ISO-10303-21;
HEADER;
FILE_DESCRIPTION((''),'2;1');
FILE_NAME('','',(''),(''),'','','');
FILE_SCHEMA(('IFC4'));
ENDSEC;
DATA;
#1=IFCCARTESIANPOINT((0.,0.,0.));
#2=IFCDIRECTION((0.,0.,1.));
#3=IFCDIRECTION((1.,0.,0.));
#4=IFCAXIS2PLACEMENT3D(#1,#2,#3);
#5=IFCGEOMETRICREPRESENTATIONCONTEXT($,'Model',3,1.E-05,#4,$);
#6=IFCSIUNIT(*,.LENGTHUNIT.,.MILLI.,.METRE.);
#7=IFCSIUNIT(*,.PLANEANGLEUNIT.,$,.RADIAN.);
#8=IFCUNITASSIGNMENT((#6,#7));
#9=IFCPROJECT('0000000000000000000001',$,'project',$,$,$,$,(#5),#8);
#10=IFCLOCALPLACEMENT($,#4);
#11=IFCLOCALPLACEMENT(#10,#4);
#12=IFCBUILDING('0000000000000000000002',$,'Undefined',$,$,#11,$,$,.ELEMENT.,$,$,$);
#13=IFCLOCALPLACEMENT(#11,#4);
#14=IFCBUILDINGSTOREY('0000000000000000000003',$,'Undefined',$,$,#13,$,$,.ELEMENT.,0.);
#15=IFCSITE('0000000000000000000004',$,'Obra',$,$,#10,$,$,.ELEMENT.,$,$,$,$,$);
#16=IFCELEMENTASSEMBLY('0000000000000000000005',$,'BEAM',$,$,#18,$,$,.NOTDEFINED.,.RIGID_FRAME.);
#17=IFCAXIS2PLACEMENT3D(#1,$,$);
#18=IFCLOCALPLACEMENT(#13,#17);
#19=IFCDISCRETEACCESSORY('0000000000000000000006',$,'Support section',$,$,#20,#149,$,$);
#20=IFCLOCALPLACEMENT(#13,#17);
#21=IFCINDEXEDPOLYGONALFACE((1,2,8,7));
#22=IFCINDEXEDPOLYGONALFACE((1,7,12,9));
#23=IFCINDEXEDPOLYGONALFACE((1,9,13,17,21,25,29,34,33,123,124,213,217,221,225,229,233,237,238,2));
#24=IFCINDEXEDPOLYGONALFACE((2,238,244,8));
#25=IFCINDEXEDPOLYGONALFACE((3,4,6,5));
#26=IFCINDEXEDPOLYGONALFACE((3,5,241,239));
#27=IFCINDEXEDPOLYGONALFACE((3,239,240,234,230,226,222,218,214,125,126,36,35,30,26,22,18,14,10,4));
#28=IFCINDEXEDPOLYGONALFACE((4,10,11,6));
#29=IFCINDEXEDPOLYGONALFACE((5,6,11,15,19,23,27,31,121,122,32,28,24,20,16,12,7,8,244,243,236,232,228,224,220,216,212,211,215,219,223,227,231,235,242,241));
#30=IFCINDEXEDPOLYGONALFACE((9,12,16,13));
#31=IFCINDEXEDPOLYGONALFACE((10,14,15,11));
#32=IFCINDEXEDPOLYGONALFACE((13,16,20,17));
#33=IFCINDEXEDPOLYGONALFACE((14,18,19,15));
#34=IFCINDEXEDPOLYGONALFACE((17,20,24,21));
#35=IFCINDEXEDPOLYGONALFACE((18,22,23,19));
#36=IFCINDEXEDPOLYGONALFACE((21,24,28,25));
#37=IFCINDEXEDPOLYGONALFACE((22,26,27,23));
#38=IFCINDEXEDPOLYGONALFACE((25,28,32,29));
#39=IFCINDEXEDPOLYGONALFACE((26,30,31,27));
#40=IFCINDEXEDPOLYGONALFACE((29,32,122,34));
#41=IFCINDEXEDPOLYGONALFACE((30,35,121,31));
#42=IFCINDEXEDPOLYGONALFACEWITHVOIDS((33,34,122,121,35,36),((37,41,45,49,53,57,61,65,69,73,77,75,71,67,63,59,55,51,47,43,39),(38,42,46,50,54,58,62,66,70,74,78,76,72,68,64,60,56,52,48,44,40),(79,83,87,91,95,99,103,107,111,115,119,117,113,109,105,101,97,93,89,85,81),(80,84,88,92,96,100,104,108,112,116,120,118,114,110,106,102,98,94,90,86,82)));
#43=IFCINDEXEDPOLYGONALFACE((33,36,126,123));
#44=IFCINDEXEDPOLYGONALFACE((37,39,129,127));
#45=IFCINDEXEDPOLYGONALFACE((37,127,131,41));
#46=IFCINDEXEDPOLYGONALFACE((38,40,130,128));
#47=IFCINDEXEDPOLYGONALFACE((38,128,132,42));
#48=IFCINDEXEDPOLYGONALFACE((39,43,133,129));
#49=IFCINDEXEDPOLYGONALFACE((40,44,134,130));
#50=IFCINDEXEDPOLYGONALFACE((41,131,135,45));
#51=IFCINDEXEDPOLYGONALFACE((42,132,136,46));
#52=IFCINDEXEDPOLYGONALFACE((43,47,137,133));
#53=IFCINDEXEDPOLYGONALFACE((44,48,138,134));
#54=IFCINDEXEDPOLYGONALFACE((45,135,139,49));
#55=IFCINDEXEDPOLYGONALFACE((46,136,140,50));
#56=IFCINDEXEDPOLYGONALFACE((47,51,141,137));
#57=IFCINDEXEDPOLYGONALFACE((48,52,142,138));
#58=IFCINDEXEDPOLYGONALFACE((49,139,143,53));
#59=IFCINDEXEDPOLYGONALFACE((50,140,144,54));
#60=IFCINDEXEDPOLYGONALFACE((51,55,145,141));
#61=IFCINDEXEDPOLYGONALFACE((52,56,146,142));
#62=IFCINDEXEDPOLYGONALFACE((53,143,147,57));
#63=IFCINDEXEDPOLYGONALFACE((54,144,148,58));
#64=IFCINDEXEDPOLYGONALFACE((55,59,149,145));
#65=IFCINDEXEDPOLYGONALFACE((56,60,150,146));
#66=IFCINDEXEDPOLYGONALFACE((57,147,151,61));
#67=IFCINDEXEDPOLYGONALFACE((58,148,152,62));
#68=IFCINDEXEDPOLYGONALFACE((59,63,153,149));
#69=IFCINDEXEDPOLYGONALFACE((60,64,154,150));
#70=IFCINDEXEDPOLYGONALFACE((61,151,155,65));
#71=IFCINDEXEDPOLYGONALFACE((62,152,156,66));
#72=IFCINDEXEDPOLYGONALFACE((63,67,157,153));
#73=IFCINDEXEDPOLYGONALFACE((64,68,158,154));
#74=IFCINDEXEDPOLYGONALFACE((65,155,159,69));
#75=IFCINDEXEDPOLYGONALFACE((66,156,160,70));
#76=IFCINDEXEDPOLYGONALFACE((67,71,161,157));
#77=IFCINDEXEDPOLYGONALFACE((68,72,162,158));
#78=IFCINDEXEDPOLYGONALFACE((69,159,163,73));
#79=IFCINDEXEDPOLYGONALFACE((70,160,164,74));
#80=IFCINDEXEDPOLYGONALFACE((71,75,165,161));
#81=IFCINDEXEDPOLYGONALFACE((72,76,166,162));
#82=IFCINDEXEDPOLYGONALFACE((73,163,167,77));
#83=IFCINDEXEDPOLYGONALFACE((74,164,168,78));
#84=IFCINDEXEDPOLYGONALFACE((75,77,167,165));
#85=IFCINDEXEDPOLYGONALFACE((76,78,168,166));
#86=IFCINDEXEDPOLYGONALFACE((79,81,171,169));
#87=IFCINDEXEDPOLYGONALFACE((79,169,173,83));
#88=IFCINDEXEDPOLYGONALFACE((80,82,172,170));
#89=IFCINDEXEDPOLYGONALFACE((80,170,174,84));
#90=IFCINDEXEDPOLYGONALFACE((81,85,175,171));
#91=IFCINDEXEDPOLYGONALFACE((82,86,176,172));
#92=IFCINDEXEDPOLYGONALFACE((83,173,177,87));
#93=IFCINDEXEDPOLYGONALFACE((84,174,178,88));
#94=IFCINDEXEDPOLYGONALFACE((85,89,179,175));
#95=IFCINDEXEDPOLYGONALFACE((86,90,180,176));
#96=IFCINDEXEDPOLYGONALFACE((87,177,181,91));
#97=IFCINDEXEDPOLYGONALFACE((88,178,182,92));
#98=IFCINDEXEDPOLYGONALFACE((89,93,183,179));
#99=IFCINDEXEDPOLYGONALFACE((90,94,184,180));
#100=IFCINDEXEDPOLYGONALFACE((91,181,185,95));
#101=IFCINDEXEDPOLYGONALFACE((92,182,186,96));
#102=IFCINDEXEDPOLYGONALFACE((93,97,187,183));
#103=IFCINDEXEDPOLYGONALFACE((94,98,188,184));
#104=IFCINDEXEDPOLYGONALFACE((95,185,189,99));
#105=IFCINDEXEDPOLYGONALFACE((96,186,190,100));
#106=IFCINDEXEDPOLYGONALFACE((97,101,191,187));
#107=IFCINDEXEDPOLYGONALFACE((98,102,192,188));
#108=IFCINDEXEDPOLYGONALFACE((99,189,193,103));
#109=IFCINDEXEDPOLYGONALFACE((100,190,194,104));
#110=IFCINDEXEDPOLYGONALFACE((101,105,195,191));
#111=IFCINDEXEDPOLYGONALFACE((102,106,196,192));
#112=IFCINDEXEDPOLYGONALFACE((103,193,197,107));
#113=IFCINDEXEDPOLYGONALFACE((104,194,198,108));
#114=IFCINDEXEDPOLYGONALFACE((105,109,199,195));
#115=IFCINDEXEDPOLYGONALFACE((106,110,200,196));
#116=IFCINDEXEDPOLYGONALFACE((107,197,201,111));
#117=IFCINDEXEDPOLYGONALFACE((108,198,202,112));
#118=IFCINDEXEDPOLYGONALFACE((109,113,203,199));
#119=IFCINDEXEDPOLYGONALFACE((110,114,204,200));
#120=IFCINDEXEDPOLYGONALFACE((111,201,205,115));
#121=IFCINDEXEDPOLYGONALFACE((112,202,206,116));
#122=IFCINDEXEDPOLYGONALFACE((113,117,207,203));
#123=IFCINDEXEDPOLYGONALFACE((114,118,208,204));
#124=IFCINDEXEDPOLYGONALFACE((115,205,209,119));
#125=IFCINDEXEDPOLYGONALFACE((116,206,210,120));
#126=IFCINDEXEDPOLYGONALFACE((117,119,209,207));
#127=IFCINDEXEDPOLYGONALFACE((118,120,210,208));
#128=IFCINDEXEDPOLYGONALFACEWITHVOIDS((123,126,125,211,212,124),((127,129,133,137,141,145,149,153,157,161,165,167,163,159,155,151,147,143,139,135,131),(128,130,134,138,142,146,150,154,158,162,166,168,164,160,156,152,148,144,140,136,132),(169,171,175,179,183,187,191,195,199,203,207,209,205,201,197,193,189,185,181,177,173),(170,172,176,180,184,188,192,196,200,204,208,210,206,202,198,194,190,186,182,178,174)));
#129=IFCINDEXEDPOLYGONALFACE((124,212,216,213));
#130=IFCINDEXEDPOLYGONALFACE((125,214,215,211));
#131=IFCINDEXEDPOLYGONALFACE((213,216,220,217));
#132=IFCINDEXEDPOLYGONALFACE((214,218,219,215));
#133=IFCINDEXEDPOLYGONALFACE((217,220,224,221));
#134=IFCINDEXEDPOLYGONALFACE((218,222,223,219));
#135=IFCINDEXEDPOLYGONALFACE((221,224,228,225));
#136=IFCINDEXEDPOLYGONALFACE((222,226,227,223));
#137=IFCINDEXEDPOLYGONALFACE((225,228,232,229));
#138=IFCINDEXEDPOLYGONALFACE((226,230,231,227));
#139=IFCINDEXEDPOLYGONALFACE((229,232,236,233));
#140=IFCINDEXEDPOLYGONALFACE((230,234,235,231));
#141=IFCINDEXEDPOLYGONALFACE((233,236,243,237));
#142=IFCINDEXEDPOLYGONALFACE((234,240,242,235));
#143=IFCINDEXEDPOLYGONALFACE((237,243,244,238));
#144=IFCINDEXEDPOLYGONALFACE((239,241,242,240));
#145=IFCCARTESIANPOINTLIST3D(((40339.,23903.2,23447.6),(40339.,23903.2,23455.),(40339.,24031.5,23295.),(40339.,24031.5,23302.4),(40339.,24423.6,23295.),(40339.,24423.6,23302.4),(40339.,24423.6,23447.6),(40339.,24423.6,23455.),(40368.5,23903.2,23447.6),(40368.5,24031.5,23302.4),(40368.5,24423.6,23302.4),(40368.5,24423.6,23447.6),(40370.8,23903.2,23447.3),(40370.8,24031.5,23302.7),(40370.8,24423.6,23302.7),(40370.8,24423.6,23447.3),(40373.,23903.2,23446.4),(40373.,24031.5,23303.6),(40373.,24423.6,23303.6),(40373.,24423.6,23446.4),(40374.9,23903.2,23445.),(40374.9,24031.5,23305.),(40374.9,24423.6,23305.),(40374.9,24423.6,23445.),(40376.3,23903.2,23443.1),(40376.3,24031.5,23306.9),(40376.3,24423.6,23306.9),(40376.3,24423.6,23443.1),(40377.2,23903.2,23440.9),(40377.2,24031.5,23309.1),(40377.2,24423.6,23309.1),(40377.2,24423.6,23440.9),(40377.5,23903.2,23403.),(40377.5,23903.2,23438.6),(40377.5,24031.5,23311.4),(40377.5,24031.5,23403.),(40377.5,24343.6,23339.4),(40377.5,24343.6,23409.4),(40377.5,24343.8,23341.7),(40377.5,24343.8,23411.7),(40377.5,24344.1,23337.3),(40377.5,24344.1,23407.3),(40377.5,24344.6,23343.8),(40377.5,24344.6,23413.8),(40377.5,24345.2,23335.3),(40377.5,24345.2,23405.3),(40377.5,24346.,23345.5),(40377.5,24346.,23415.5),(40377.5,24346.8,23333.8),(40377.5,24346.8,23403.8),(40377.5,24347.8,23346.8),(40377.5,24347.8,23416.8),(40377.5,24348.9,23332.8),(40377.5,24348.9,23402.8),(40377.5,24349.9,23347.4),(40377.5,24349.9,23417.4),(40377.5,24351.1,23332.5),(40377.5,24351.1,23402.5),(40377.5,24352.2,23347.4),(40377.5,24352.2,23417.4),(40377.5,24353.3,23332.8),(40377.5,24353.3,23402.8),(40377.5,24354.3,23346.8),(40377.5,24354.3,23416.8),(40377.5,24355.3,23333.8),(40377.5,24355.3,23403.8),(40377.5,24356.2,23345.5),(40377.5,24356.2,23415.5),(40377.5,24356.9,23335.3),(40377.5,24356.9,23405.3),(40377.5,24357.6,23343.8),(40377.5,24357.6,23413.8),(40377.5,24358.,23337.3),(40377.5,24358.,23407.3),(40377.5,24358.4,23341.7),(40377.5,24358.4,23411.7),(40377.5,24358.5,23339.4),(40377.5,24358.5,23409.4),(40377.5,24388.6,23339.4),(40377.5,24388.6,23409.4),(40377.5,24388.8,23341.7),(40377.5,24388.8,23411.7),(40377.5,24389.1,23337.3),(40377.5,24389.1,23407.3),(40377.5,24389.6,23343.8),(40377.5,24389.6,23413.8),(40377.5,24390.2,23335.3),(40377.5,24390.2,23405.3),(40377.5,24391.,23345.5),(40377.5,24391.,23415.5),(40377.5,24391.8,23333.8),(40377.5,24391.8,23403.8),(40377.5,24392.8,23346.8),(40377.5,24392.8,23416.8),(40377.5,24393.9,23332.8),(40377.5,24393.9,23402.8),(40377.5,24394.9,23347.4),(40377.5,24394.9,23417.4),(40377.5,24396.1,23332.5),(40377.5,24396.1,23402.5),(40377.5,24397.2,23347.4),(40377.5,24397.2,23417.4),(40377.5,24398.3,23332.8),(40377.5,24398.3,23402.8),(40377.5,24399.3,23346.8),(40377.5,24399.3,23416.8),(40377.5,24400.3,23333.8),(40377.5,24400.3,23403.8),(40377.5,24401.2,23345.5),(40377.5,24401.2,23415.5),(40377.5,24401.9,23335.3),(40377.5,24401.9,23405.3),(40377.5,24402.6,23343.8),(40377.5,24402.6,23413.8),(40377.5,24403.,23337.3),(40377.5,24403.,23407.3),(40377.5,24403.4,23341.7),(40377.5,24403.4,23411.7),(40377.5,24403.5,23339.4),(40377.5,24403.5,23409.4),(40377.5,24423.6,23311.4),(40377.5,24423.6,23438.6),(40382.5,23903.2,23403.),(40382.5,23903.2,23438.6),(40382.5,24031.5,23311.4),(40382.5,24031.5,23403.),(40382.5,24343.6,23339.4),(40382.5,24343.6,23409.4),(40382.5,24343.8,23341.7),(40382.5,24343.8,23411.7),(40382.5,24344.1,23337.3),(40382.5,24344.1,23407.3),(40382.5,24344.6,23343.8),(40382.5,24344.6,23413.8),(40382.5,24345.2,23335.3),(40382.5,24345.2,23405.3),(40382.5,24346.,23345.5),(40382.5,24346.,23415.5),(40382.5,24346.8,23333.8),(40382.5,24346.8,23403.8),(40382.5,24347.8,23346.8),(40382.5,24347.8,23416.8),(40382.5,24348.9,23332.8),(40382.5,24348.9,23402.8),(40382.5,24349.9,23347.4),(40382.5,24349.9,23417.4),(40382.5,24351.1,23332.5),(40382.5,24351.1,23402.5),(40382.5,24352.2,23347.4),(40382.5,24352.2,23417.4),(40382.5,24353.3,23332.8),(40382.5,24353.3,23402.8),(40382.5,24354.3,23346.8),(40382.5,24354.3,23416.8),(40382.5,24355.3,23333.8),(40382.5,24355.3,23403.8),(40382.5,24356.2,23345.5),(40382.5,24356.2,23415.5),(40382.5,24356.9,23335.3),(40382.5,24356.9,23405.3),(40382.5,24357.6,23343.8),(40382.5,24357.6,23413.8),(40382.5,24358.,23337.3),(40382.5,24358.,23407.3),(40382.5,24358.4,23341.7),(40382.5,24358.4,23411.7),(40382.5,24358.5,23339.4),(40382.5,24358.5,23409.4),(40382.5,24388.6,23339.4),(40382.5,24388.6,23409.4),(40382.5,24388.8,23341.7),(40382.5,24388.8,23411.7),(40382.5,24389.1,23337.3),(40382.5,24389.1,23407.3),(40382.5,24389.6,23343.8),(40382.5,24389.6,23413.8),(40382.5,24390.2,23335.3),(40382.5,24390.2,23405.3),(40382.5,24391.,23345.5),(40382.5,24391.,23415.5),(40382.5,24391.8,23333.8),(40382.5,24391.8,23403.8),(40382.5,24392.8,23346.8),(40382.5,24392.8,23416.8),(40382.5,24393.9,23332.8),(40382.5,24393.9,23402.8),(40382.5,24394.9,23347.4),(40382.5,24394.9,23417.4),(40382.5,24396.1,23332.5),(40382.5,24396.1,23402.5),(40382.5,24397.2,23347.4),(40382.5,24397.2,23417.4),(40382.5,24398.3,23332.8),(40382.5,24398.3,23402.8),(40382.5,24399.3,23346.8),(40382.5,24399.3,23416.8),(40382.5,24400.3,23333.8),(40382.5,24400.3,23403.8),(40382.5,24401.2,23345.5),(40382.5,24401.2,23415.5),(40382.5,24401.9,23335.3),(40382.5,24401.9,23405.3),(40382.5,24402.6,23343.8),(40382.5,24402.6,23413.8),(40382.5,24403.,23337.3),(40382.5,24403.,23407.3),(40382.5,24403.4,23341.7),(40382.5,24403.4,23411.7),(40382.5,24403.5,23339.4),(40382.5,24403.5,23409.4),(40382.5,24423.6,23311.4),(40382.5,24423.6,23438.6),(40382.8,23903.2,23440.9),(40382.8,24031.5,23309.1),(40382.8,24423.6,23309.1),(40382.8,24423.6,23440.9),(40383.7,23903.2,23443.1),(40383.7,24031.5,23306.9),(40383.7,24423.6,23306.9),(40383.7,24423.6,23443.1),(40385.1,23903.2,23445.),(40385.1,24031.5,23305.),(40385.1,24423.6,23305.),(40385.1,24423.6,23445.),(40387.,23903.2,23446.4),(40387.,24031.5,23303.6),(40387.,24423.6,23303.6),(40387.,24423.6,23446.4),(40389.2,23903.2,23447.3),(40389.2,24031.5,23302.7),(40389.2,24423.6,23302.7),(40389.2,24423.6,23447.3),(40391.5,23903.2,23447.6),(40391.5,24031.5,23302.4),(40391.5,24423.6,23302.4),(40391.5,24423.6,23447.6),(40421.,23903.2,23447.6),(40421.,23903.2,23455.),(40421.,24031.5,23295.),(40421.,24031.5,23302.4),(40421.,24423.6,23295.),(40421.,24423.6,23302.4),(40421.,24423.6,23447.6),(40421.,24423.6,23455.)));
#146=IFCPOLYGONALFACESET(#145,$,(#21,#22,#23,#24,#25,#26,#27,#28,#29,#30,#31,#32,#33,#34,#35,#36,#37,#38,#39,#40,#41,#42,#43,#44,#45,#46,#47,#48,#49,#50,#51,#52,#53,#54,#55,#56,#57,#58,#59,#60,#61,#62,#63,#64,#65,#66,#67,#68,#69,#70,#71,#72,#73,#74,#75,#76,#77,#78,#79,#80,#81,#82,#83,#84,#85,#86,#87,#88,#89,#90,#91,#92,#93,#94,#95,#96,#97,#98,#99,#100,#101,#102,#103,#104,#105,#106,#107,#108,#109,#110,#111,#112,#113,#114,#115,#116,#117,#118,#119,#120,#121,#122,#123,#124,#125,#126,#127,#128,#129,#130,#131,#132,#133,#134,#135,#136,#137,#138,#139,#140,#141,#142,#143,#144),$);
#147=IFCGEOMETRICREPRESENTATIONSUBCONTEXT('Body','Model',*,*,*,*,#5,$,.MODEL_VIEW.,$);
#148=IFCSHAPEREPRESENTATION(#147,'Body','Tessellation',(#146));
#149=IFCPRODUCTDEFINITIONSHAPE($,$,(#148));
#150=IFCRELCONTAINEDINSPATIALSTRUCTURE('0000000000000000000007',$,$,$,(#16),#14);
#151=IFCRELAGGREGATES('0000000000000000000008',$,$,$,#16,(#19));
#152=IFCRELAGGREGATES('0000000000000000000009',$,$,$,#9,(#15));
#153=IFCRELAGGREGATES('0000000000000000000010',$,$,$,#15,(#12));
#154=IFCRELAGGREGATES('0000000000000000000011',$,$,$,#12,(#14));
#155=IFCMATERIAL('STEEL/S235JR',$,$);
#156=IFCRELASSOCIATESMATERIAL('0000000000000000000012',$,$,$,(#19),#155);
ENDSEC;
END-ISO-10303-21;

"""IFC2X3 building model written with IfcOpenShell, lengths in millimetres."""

from ifc_helpers import new_model, si_unit, frame, origin_with_axes, origin_2d_with_axis, place, context, subcontext, project, spatial, rectangle, circle, i_section, extrude, clip, halfspace, source, transform, mapped, material, element, aggregate, save


model = new_model("IFC2X3")

# Units and contexts
model_context = context("Model", 3, precision=1e-05, world=origin_with_axes())
body_context = subcontext(model_context, "Body", "Model", "MODEL_VIEW")
ifc_project = project(units=[si_unit("LENGTHUNIT", "METRE", prefix="MILLI"), si_unit("PLANEANGLEUNIT", "RADIAN")], contexts=[model_context])

# Site, building, storey
site_placement = place(None, origin_with_axes())
site = spatial("IfcSite", under=ifc_project, at=site_placement, Name="Obra", CompositionType="ELEMENT")
building_placement = place(site_placement, origin_with_axes())
building = spatial("IfcBuilding", under=site, at=building_placement, Name="Undefined", CompositionType="ELEMENT")
storey_placement = place(building_placement, origin_with_axes())
storey = spatial("IfcBuildingStorey", under=building, at=storey_placement, Name="Undefined", CompositionType="ELEMENT", Elevation=0.0)

# Element assembly
assembly_1_placement = place(storey_placement, origin_with_axes())
assembly_1 = element("IfcElementAssembly", 1, at=assembly_1_placement, inside=storey, Name="BEAM", AssemblyPlace="NOTDEFINED", PredefinedType="RIGID_FRAME")

# Shared definitions
ifc_material_1 = material(Name="STEEL/S235JR")

# Discrete accessory, openings
discrete_accessory_1_placement = place(assembly_1_placement, frame((40380.0, 23901.0, 23375.0), z_axis=(0.0, 0.0, 1.0), x_axis=(0.0, 1.0, 0.0)))
discrete_accessory_1 = element("IfcDiscreteAccessory", 2, at=discrete_accessory_1_placement, material=ifc_material_1, Name="Support section", context=body_context, shape_type="Clipping", body=[
    clip(clip(extrude(i_section(OverallWidth=82.0, OverallDepth=160.0, WebThickness=5.0, FlangeThickness=7.4, FilletRadius=9.0, at=origin_2d_with_axis()), frame((522.6, 0.0, 0.0), z_axis=(-1.0, 0.0, 0.0), x_axis=(0.0, -1.0, 0.0)), (0.0, 0.0, 1.0), 520.3), halfspace(frame((522.6, 0.0, -180.0), z_axis=(-1.0, 0.0, 0.0), x_axis=(0.0, 1.0, 0.0)), True)), halfspace(frame((2.3, 0.0, -180.0), z_axis=(-1.0, 0.0, 0.0), x_axis=(0.0, 1.0, 0.0)), False)),
])
opening_1_placement = place(assembly_1_placement, frame((40380.0, 23901.0, 23375.0), z_axis=(0.0, 0.0, 1.0), x_axis=(0.0, 1.0, 0.0)))
element("IfcOpeningElement", 3, at=opening_1_placement, cuts=discrete_accessory_1, ObjectType="Recess", context=body_context, shape_type="SweptSolid", body=[
    extrude(rectangle(XDim=109.0, YDim=1295.4, at=origin_2d_with_axis()), frame((-517.2, 42.0, -26.5), z_axis=(0.0, -1.0, 0.0), x_axis=(0.0, 0.0, -1.0)), (0.0, 0.0, 1.0), 84.0),
])
shared_shape_1 = source(origin_with_axes(), body_context, "Body", "SweptSolid", [
    extrude(circle(Radius=7.5, at=origin_2d_with_axis()), frame((0.0, -2.6, 0.0), z_axis=(0.0, 1.0, 0.0), x_axis=(1.0, 0.0, 0.0)), (0.0, 0.0, 1.0), 5.2),
])
opening_2_placement = place(assembly_1_placement, frame((40380.0, 24373.6, 23410.0), z_axis=(0.0, -1.0, 0.0), x_axis=(0.0, 0.0, -1.0)))
element("IfcOpeningElement", 4, at=opening_2_placement, cuts=discrete_accessory_1, ObjectType="Opening", context=body_context, shape_type="MappedRepresentation", body=[
    mapped(shared_shape_1, transform((0.0, 0.0, -22.5))),
    mapped(shared_shape_1, transform((70.0, 0.0, -22.5))),
    mapped(shared_shape_1, transform((0.0, 0.0, 22.5))),
    mapped(shared_shape_1, transform((70.0, 0.0, 22.5))),
])

aggregate(assembly_1, [discrete_accessory_1])

save(model, "model.ifc")
